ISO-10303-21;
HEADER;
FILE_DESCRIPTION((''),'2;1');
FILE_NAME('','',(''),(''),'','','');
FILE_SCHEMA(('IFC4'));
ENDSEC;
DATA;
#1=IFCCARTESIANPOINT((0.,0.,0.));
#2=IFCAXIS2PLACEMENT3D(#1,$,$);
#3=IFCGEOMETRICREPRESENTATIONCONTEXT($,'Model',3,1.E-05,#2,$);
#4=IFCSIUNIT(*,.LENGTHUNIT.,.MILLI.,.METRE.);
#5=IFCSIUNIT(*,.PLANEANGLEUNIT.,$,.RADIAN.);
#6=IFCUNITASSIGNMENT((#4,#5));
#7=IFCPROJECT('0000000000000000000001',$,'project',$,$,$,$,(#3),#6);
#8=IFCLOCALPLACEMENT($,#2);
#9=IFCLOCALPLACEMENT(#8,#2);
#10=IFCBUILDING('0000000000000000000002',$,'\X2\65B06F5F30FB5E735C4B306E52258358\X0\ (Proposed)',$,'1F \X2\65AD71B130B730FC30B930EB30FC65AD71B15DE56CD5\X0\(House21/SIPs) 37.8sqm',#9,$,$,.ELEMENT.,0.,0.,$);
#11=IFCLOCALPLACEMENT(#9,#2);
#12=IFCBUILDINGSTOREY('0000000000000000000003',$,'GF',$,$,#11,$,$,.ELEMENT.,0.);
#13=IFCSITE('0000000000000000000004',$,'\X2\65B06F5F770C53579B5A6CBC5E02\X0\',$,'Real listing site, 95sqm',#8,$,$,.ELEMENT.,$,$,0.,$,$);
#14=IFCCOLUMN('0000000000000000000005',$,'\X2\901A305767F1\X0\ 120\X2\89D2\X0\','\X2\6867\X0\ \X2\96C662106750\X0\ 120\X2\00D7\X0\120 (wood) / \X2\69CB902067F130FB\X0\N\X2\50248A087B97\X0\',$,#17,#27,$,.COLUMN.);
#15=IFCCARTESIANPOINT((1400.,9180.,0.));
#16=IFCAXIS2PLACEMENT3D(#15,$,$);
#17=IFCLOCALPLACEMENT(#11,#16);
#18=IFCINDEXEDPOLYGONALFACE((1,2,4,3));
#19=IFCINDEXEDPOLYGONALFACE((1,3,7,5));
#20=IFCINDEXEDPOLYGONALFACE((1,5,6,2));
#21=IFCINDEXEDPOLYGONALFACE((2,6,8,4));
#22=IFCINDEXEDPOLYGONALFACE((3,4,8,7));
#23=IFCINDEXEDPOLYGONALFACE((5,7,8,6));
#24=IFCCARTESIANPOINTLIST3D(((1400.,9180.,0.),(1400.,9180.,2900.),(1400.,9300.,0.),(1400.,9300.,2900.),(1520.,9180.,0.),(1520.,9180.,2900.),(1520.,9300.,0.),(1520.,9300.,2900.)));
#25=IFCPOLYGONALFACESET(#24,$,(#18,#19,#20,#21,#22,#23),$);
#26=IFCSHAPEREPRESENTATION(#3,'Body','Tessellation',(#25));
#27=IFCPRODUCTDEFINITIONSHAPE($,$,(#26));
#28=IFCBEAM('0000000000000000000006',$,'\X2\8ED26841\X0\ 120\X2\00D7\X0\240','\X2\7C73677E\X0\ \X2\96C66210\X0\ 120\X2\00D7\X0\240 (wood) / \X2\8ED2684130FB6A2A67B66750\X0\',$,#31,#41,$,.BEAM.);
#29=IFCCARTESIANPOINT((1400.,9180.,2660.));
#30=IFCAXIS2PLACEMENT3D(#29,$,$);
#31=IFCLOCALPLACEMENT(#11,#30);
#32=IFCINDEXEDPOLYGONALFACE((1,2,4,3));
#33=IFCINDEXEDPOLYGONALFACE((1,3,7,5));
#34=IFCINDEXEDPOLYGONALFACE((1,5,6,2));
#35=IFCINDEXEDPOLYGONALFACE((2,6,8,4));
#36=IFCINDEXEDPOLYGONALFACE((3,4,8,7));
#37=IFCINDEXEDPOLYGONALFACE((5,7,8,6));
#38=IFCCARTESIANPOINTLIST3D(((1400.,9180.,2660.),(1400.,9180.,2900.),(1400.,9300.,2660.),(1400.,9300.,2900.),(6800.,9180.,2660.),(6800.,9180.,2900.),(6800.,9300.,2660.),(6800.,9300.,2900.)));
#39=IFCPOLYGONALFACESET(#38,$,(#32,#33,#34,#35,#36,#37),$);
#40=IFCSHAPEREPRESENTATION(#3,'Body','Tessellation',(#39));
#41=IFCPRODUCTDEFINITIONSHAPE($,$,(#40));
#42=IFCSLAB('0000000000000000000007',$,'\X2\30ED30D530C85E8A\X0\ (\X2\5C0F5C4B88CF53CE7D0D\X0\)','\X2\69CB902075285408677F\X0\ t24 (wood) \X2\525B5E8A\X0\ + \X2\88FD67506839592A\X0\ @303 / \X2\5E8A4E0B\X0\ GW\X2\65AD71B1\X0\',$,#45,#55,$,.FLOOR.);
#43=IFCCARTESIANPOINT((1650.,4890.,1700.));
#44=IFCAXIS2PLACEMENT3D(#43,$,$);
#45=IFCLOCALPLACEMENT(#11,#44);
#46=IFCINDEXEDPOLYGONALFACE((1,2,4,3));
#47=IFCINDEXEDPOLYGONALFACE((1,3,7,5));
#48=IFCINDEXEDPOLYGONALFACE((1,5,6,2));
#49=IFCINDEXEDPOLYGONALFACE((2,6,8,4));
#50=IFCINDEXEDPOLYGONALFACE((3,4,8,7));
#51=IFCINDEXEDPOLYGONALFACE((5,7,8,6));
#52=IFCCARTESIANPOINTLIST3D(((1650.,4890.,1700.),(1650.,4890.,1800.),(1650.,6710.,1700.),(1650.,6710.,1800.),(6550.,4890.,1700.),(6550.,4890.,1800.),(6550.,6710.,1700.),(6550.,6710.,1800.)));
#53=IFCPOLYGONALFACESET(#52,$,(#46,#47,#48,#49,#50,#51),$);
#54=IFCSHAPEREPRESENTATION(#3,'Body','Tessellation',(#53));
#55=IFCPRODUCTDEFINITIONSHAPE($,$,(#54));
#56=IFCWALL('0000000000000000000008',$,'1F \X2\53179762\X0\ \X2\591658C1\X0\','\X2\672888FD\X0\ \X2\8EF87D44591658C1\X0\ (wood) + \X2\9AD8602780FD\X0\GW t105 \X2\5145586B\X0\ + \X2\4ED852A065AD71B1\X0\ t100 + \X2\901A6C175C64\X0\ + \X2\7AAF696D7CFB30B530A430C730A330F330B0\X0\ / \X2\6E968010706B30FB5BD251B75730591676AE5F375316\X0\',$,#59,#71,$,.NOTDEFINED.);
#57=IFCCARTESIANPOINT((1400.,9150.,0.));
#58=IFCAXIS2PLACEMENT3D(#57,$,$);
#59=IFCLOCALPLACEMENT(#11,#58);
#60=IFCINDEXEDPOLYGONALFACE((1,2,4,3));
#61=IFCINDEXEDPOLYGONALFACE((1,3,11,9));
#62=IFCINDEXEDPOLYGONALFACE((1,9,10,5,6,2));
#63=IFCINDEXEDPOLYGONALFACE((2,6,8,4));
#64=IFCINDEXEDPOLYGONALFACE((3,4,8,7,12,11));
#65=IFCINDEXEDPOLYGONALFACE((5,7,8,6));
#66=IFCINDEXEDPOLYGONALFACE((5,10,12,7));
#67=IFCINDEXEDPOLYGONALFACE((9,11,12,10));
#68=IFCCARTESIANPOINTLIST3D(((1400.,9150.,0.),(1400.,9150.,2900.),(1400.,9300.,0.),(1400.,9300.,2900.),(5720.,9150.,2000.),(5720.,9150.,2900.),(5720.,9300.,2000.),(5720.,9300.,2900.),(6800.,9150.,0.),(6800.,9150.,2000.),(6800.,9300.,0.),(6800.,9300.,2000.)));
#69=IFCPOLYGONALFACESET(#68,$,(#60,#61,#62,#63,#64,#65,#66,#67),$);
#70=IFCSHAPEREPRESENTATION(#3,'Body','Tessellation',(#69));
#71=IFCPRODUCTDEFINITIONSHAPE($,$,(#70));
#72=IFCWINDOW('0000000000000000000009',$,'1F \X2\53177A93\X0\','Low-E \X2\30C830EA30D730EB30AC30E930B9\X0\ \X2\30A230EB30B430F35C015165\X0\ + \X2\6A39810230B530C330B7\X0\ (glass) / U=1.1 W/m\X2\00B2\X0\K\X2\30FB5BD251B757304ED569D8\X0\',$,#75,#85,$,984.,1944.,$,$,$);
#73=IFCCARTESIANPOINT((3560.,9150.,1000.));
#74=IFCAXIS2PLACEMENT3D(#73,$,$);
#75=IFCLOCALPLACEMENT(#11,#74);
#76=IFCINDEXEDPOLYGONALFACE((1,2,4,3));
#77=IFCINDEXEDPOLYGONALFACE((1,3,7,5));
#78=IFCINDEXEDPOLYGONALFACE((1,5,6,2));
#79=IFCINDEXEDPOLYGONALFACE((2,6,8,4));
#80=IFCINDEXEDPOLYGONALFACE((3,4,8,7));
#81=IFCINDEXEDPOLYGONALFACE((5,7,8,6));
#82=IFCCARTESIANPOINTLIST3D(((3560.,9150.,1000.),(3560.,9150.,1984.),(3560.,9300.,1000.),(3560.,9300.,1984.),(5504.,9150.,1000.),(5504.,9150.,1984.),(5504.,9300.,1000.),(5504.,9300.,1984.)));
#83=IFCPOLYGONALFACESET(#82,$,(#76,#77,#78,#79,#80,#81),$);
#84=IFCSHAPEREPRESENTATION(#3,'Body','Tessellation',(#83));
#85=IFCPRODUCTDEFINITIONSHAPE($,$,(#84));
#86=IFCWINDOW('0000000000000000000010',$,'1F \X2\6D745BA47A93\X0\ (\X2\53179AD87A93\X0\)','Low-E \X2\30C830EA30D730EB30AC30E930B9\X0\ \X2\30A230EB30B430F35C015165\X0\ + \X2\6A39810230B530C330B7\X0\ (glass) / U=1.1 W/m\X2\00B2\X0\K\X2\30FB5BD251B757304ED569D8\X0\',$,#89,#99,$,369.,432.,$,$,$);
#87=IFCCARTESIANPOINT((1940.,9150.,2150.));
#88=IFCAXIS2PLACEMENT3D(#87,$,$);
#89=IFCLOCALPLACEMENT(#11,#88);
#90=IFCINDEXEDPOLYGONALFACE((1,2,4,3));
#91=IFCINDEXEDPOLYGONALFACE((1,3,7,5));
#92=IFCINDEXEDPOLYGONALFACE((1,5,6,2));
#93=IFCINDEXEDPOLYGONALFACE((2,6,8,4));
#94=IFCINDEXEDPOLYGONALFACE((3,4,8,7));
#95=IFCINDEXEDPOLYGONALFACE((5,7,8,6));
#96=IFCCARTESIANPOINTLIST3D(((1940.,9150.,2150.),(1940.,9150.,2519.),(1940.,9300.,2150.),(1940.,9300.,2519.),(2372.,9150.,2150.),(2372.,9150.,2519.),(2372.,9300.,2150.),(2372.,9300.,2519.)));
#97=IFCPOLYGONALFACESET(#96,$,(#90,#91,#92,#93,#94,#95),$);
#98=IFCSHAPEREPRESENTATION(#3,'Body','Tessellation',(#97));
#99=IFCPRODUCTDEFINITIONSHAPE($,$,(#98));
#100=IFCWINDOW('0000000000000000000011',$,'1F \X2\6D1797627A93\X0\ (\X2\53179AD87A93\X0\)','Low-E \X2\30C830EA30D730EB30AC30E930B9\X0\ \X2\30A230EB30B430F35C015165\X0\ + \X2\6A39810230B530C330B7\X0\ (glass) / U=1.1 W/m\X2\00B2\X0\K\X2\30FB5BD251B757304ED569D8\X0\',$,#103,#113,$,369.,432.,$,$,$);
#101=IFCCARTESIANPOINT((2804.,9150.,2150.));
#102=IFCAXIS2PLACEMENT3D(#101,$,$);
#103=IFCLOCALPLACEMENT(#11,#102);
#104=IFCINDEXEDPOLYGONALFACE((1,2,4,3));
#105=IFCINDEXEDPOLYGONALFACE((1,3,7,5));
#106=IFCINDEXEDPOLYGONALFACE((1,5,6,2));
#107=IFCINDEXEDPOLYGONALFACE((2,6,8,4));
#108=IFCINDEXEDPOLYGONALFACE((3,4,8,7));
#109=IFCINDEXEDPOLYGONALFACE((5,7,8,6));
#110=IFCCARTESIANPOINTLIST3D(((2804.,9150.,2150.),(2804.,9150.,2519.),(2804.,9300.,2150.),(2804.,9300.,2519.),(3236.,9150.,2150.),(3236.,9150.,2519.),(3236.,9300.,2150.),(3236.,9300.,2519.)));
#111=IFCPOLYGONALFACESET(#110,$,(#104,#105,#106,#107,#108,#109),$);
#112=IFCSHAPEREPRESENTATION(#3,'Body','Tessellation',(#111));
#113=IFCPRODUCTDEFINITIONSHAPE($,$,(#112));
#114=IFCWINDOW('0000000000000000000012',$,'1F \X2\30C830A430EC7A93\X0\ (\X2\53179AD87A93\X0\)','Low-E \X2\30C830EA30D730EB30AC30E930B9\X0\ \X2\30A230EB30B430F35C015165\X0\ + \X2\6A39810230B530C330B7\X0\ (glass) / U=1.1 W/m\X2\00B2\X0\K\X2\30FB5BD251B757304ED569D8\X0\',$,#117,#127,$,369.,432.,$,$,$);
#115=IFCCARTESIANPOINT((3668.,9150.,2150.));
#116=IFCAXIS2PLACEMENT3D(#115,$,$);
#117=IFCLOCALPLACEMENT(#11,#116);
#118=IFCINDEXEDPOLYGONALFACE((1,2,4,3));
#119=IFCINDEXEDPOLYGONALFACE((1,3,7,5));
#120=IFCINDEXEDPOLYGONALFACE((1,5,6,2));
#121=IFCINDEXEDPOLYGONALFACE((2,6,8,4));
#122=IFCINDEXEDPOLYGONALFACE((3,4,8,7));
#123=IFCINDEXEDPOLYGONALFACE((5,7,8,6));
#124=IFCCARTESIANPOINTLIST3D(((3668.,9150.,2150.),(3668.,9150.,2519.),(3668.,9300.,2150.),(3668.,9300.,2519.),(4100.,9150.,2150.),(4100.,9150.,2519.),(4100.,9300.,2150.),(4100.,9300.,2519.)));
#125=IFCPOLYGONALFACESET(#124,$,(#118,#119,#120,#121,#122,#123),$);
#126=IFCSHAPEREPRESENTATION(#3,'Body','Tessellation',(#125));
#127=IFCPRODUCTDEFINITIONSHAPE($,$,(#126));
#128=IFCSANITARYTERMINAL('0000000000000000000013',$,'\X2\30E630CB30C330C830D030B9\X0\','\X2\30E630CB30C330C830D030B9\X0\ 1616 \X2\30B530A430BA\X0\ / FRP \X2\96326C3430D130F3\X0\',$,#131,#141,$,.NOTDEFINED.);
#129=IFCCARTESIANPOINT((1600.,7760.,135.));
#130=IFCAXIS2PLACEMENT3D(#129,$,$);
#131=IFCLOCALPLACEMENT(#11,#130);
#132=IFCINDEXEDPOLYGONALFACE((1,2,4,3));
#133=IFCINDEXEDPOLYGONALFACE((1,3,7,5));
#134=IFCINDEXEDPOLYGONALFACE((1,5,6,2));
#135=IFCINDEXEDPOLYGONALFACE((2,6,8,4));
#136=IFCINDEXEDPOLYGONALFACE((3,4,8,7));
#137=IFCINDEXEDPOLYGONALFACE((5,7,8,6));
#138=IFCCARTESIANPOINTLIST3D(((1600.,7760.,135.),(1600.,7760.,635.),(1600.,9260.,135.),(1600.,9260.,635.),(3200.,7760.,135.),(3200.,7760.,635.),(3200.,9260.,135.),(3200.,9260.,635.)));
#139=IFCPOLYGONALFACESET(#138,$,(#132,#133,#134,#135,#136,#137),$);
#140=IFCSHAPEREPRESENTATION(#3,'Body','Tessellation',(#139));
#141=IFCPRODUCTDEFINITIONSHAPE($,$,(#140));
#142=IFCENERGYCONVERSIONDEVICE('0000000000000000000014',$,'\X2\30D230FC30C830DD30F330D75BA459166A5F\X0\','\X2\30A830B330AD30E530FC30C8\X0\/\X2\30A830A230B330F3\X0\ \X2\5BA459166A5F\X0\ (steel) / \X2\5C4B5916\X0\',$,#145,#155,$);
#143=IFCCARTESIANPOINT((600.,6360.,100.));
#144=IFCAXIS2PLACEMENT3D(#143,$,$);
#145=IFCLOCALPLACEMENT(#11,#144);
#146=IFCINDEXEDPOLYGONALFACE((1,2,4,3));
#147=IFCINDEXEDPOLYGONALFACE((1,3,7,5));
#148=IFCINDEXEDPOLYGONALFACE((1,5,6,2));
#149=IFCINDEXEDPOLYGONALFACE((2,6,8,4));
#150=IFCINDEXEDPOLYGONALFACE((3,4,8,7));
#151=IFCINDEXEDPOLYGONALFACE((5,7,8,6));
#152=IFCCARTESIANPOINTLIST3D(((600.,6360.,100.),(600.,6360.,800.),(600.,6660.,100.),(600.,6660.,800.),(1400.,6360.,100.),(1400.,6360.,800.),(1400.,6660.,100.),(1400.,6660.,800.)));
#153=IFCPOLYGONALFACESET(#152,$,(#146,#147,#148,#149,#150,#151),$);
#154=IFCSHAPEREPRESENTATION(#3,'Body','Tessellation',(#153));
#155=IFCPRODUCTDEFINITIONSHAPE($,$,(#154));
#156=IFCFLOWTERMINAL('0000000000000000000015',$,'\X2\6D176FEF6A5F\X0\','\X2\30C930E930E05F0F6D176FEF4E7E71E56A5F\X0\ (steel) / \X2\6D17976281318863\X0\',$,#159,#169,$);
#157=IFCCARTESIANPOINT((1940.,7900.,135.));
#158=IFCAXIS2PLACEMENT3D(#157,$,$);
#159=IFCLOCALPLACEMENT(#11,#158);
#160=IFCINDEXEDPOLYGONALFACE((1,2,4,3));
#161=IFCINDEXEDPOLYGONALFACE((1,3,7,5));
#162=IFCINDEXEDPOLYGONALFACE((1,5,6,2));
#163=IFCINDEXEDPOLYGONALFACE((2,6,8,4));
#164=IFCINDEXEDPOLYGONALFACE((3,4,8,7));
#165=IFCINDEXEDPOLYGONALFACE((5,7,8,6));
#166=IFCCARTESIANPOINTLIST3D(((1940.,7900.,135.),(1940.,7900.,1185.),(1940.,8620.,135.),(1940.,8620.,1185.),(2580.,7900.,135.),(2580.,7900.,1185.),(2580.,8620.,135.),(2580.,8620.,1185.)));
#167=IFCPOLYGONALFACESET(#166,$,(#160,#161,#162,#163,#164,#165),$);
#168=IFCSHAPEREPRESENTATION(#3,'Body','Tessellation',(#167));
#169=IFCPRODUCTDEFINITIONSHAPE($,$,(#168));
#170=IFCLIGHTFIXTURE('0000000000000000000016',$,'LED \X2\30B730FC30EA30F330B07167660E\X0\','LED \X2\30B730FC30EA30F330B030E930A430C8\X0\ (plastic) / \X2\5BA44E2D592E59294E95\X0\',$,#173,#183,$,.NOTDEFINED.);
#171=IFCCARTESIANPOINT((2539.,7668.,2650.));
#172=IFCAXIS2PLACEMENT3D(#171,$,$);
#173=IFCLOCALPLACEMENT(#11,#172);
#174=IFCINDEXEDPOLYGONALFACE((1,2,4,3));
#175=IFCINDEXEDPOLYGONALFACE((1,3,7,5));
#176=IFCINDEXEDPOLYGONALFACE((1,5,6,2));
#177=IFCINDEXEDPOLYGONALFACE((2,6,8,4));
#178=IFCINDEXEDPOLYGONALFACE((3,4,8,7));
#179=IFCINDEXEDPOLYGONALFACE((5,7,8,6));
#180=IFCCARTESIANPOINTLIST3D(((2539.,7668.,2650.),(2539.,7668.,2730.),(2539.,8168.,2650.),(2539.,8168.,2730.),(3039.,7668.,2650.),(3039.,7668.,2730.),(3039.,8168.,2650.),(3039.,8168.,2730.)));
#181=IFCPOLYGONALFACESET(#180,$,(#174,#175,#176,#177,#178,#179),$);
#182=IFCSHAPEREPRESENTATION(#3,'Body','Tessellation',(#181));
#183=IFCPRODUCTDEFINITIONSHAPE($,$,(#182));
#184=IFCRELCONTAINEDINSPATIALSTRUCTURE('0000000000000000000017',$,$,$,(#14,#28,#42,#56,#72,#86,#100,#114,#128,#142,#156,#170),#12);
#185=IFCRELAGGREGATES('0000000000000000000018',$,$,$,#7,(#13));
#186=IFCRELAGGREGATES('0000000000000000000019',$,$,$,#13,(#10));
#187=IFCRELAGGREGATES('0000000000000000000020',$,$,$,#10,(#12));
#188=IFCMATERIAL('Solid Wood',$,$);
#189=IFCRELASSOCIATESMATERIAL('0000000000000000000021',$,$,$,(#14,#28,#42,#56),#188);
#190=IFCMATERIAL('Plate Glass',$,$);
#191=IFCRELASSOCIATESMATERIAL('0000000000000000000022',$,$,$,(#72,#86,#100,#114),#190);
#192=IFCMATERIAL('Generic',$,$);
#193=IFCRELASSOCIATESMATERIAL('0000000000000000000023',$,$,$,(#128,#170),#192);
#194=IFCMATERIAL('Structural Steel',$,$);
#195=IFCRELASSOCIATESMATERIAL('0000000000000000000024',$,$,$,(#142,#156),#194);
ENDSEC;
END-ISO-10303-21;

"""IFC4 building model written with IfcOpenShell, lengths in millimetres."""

from ifc_helpers import new_model, si_unit, frame, frame_2d, origin, place, context, project, spatial, rectangle, extrude, material, element, fill, save


model = new_model("IFC4")

# Units and contexts
model_context = context("Model", 3, precision=1e-05, world=origin())
ifc_project = project(units=[si_unit("LENGTHUNIT", "METRE", prefix="MILLI"), si_unit("PLANEANGLEUNIT", "RADIAN")], contexts=[model_context])

# Site, building, storey
site_placement = place(None, origin())
site = spatial("IfcSite", under=ifc_project, at=site_placement, Name="新潟県南魚沼市", ObjectType="Real listing site, 95sqm", CompositionType="ELEMENT", RefElevation=0.0)
building_placement = place(site_placement, origin())
building = spatial("IfcBuilding", under=site, at=building_placement, Name="新潟・平屋の別荘 (Proposed)", ObjectType="1F 断熱シースルー断熱工法(House21/SIPs) 37.8sqm", CompositionType="ELEMENT", ElevationOfRefHeight=0.0, ElevationOfTerrain=0.0)
storey_placement = place(building_placement, origin())
storey = spatial("IfcBuildingStorey", under=building, at=storey_placement, Name="GF", CompositionType="ELEMENT", Elevation=0.0)

# Column
ifc_material_1 = material(Name="Solid Wood")
column_1_placement = place(storey_placement, frame((1400.0, 9180.0, 0.0)))
element("IfcColumn", 1, at=column_1_placement, inside=storey, material=ifc_material_1, Name="通し柱 120角", Description="桧 集成材 120×120 (wood) / 構造柱・N値計算", PredefinedType="COLUMN", context=model_context, shape_type="SweptSolid", body=[
    extrude(rectangle(XDim=120.0, YDim=120.0, at=frame_2d((60.0, 60.0))), frame((1400.0, 9180.0, 0.0)), (0.0, 0.0, 1.0), 2900.0),
])

# Beam
beam_1_placement = place(storey_placement, frame((1400.0, 9180.0, 2660.0)))
element("IfcBeam", 2, at=beam_1_placement, inside=storey, material=ifc_material_1, Name="軒桁 120×240", Description="米松 集成 120×240 (wood) / 軒桁・横架材", PredefinedType="BEAM", context=model_context, shape_type="SweptSolid", body=[
    extrude(rectangle(XDim=5400.0, YDim=120.0, at=frame_2d((2700.0, 60.0))), frame((1400.0, 9180.0, 2660.0)), (0.0, 0.0, 1.0), 240.0),
])

# Slab
slab_placement = place(storey_placement, frame((1650.0, 4890.0, 1700.0)))
element("IfcSlab", 3, at=slab_placement, inside=storey, material=ifc_material_1, Name="ロフト床 (小屋裏収納)", Description="構造用合板 t24 (wood) 剛床 + 製材根太 @303 / 床下 GW断熱", PredefinedType="FLOOR", context=model_context, shape_type="SweptSolid", body=[
    extrude(rectangle(XDim=4900.0, YDim=1820.0, at=frame_2d((2450.0, 910.0))), frame((1650.0, 4890.0, 1700.0)), (0.0, 0.0, 1.0), 100.0),
])

# Wall, openings, windows
wall_1_placement = place(storey_placement, frame((1400.0, 9150.0, 0.0)))
wall_1 = element("IfcWall", 4, at=wall_1_placement, inside=storey, material=ifc_material_1, Name="1F 北面 外壁", Description="木製 軸組外壁 (wood) + 高性能GW t105 充填 + 付加断熱 t100 + 通気層 + 窯業系サイディング / 準耐火・寒冷地外皮強化", PredefinedType="NOTDEFINED", context=model_context, shape_type="SweptSolid", body=[
    extrude(rectangle(XDim=5400.0, YDim=150.0, at=frame_2d((2700.0, 75.0))), frame((1400.0, 9150.0, 0.0)), (0.0, 0.0, 1.0), 2900.0),
])
opening_1_placement = place(storey_placement, frame((3560.0, 9150.0, 1000.0)))
opening_1 = element("IfcOpeningElement", 5, at=opening_1_placement, cuts=wall_1, PredefinedType="NOTDEFINED", context=model_context, shape_type="SweptSolid", body=[
    extrude(rectangle(XDim=1944.0, YDim=150.0, at=frame_2d((972.0, 75.0))), frame((3560.0, 9150.0, 1000.0)), (0.0, 0.0, 1.0), 984.0),
])
opening_2_placement = place(storey_placement, frame((1940.0, 9150.0, 2150.0)))
opening_2 = element("IfcOpeningElement", 6, at=opening_2_placement, cuts=wall_1, PredefinedType="NOTDEFINED", context=model_context, shape_type="SweptSolid", body=[
    extrude(rectangle(XDim=432.0, YDim=150.0, at=frame_2d((216.0, 75.0))), frame((1940.0, 9150.0, 2150.0)), (0.0, 0.0, 1.0), 369.0),
])
opening_3_placement = place(storey_placement, frame((2804.0, 9150.0, 2150.0)))
opening_3 = element("IfcOpeningElement", 7, at=opening_3_placement, cuts=wall_1, PredefinedType="NOTDEFINED", context=model_context, shape_type="SweptSolid", body=[
    extrude(rectangle(XDim=432.0, YDim=150.0, at=frame_2d((216.0, 75.0))), frame((2804.0, 9150.0, 2150.0)), (0.0, 0.0, 1.0), 369.0),
])
opening_4_placement = place(storey_placement, frame((3668.0, 9150.0, 2150.0)))
opening_4 = element("IfcOpeningElement", 8, at=opening_4_placement, cuts=wall_1, PredefinedType="NOTDEFINED", context=model_context, shape_type="SweptSolid", body=[
    extrude(rectangle(XDim=432.0, YDim=150.0, at=frame_2d((216.0, 75.0))), frame((3668.0, 9150.0, 2150.0)), (0.0, 0.0, 1.0), 369.0),
])
ifc_material_2 = material(Name="Plate Glass")
window_1_placement = place(storey_placement, frame((3560.0, 9150.0, 1000.0)))
window_1 = element("IfcWindow", 9, at=window_1_placement, inside=storey, material=ifc_material_2, Name="1F 北窓", Description="Low-E トリプルガラス アルゴン封入 + 樹脂サッシ (glass) / U=1.1 W/m²K・寒冷地仕様", OverallHeight=984.0, OverallWidth=1944.0, context=model_context, shape_type="SweptSolid", body=[
    extrude(rectangle(XDim=1944.0, YDim=150.0, at=frame_2d((972.0, 75.0))), frame((3560.0, 9150.0, 1000.0)), (0.0, 0.0, 1.0), 984.0),
])
fill(opening_1, window_1)
window_2_placement = place(storey_placement, frame((1940.0, 9150.0, 2150.0)))
window_2 = element("IfcWindow", 10, at=window_2_placement, inside=storey, material=ifc_material_2, Name="1F 浴室窓 (北高窓)", Description="Low-E トリプルガラス アルゴン封入 + 樹脂サッシ (glass) / U=1.1 W/m²K・寒冷地仕様", OverallHeight=369.0, OverallWidth=432.0, context=model_context, shape_type="SweptSolid", body=[
    extrude(rectangle(XDim=432.0, YDim=150.0, at=frame_2d((216.0, 75.0))), frame((1940.0, 9150.0, 2150.0)), (0.0, 0.0, 1.0), 369.0),
])
fill(opening_2, window_2)
window_3_placement = place(storey_placement, frame((2804.0, 9150.0, 2150.0)))
window_3 = element("IfcWindow", 11, at=window_3_placement, inside=storey, material=ifc_material_2, Name="1F 洗面窓 (北高窓)", Description="Low-E トリプルガラス アルゴン封入 + 樹脂サッシ (glass) / U=1.1 W/m²K・寒冷地仕様", OverallHeight=369.0, OverallWidth=432.0, context=model_context, shape_type="SweptSolid", body=[
    extrude(rectangle(XDim=432.0, YDim=150.0, at=frame_2d((216.0, 75.0))), frame((2804.0, 9150.0, 2150.0)), (0.0, 0.0, 1.0), 369.0),
])
fill(opening_3, window_3)
window_4_placement = place(storey_placement, frame((3668.0, 9150.0, 2150.0)))
window_4 = element("IfcWindow", 12, at=window_4_placement, inside=storey, material=ifc_material_2, Name="1F トイレ窓 (北高窓)", Description="Low-E トリプルガラス アルゴン封入 + 樹脂サッシ (glass) / U=1.1 W/m²K・寒冷地仕様", OverallHeight=369.0, OverallWidth=432.0, context=model_context, shape_type="SweptSolid", body=[
    extrude(rectangle(XDim=432.0, YDim=150.0, at=frame_2d((216.0, 75.0))), frame((3668.0, 9150.0, 2150.0)), (0.0, 0.0, 1.0), 369.0),
])
fill(opening_4, window_4)

# Sanitary terminal
ifc_material_3 = material(Name="Generic")
sanitary_terminal_placement = place(storey_placement, frame((1600.0, 7760.0, 135.0)))
element("IfcSanitaryTerminal", 13, at=sanitary_terminal_placement, inside=storey, material=ifc_material_3, Name="ユニットバス", Description="ユニットバス 1616 サイズ / FRP 防水パン", PredefinedType="NOTDEFINED", context=model_context, shape_type="SweptSolid", body=[
    extrude(rectangle(XDim=1600.0, YDim=1500.0, at=frame_2d((800.0, 750.0))), frame((1600.0, 7760.0, 135.0)), (0.0, 0.0, 1.0), 500.0),
])

# Shared definitions
ifc_material_4 = material(Name="Structural Steel")

# Energy conversion device
energy_conversion_device_placement = place(storey_placement, frame((600.0, 6360.0, 100.0)))
element("IfcEnergyConversionDevice", 14, at=energy_conversion_device_placement, inside=storey, material=ifc_material_4, Name="ヒートポンプ室外機", Description="エコキュート/エアコン 室外機 (steel) / 屋外", context=model_context, shape_type="SweptSolid", body=[
    extrude(rectangle(XDim=800.0, YDim=300.0, at=frame_2d((400.0, 150.0))), frame((600.0, 6360.0, 100.0)), (0.0, 0.0, 1.0), 700.0),
])

# Flow terminal
flow_terminal_placement = place(storey_placement, frame((1940.0, 7900.0, 135.0)))
element("IfcFlowTerminal", 15, at=flow_terminal_placement, inside=storey, material=ifc_material_4, Name="洗濯機", Description="ドラム式洗濯乾燥機 (steel) / 洗面脱衣", context=model_context, shape_type="SweptSolid", body=[
    extrude(rectangle(XDim=640.0, YDim=720.0, at=frame_2d((320.0, 360.0))), frame((1940.0, 7900.0, 135.0)), (0.0, 0.0, 1.0), 1050.0),
])

# Light fixture
light_fixture_placement = place(storey_placement, frame((2539.0, 7668.0, 2650.0)))
element("IfcLightFixture", 16, at=light_fixture_placement, inside=storey, material=ifc_material_3, Name="LED シーリング照明", Description="LED シーリングライト (plastic) / 室中央天井", PredefinedType="NOTDEFINED", context=model_context, shape_type="SweptSolid", body=[
    extrude(rectangle(XDim=500.0, YDim=500.0, at=frame_2d((250.0, 250.0))), frame((2539.0, 7668.0, 2650.0)), (0.0, 0.0, 1.0), 80.0),
])

save(model, "model.ifc")
